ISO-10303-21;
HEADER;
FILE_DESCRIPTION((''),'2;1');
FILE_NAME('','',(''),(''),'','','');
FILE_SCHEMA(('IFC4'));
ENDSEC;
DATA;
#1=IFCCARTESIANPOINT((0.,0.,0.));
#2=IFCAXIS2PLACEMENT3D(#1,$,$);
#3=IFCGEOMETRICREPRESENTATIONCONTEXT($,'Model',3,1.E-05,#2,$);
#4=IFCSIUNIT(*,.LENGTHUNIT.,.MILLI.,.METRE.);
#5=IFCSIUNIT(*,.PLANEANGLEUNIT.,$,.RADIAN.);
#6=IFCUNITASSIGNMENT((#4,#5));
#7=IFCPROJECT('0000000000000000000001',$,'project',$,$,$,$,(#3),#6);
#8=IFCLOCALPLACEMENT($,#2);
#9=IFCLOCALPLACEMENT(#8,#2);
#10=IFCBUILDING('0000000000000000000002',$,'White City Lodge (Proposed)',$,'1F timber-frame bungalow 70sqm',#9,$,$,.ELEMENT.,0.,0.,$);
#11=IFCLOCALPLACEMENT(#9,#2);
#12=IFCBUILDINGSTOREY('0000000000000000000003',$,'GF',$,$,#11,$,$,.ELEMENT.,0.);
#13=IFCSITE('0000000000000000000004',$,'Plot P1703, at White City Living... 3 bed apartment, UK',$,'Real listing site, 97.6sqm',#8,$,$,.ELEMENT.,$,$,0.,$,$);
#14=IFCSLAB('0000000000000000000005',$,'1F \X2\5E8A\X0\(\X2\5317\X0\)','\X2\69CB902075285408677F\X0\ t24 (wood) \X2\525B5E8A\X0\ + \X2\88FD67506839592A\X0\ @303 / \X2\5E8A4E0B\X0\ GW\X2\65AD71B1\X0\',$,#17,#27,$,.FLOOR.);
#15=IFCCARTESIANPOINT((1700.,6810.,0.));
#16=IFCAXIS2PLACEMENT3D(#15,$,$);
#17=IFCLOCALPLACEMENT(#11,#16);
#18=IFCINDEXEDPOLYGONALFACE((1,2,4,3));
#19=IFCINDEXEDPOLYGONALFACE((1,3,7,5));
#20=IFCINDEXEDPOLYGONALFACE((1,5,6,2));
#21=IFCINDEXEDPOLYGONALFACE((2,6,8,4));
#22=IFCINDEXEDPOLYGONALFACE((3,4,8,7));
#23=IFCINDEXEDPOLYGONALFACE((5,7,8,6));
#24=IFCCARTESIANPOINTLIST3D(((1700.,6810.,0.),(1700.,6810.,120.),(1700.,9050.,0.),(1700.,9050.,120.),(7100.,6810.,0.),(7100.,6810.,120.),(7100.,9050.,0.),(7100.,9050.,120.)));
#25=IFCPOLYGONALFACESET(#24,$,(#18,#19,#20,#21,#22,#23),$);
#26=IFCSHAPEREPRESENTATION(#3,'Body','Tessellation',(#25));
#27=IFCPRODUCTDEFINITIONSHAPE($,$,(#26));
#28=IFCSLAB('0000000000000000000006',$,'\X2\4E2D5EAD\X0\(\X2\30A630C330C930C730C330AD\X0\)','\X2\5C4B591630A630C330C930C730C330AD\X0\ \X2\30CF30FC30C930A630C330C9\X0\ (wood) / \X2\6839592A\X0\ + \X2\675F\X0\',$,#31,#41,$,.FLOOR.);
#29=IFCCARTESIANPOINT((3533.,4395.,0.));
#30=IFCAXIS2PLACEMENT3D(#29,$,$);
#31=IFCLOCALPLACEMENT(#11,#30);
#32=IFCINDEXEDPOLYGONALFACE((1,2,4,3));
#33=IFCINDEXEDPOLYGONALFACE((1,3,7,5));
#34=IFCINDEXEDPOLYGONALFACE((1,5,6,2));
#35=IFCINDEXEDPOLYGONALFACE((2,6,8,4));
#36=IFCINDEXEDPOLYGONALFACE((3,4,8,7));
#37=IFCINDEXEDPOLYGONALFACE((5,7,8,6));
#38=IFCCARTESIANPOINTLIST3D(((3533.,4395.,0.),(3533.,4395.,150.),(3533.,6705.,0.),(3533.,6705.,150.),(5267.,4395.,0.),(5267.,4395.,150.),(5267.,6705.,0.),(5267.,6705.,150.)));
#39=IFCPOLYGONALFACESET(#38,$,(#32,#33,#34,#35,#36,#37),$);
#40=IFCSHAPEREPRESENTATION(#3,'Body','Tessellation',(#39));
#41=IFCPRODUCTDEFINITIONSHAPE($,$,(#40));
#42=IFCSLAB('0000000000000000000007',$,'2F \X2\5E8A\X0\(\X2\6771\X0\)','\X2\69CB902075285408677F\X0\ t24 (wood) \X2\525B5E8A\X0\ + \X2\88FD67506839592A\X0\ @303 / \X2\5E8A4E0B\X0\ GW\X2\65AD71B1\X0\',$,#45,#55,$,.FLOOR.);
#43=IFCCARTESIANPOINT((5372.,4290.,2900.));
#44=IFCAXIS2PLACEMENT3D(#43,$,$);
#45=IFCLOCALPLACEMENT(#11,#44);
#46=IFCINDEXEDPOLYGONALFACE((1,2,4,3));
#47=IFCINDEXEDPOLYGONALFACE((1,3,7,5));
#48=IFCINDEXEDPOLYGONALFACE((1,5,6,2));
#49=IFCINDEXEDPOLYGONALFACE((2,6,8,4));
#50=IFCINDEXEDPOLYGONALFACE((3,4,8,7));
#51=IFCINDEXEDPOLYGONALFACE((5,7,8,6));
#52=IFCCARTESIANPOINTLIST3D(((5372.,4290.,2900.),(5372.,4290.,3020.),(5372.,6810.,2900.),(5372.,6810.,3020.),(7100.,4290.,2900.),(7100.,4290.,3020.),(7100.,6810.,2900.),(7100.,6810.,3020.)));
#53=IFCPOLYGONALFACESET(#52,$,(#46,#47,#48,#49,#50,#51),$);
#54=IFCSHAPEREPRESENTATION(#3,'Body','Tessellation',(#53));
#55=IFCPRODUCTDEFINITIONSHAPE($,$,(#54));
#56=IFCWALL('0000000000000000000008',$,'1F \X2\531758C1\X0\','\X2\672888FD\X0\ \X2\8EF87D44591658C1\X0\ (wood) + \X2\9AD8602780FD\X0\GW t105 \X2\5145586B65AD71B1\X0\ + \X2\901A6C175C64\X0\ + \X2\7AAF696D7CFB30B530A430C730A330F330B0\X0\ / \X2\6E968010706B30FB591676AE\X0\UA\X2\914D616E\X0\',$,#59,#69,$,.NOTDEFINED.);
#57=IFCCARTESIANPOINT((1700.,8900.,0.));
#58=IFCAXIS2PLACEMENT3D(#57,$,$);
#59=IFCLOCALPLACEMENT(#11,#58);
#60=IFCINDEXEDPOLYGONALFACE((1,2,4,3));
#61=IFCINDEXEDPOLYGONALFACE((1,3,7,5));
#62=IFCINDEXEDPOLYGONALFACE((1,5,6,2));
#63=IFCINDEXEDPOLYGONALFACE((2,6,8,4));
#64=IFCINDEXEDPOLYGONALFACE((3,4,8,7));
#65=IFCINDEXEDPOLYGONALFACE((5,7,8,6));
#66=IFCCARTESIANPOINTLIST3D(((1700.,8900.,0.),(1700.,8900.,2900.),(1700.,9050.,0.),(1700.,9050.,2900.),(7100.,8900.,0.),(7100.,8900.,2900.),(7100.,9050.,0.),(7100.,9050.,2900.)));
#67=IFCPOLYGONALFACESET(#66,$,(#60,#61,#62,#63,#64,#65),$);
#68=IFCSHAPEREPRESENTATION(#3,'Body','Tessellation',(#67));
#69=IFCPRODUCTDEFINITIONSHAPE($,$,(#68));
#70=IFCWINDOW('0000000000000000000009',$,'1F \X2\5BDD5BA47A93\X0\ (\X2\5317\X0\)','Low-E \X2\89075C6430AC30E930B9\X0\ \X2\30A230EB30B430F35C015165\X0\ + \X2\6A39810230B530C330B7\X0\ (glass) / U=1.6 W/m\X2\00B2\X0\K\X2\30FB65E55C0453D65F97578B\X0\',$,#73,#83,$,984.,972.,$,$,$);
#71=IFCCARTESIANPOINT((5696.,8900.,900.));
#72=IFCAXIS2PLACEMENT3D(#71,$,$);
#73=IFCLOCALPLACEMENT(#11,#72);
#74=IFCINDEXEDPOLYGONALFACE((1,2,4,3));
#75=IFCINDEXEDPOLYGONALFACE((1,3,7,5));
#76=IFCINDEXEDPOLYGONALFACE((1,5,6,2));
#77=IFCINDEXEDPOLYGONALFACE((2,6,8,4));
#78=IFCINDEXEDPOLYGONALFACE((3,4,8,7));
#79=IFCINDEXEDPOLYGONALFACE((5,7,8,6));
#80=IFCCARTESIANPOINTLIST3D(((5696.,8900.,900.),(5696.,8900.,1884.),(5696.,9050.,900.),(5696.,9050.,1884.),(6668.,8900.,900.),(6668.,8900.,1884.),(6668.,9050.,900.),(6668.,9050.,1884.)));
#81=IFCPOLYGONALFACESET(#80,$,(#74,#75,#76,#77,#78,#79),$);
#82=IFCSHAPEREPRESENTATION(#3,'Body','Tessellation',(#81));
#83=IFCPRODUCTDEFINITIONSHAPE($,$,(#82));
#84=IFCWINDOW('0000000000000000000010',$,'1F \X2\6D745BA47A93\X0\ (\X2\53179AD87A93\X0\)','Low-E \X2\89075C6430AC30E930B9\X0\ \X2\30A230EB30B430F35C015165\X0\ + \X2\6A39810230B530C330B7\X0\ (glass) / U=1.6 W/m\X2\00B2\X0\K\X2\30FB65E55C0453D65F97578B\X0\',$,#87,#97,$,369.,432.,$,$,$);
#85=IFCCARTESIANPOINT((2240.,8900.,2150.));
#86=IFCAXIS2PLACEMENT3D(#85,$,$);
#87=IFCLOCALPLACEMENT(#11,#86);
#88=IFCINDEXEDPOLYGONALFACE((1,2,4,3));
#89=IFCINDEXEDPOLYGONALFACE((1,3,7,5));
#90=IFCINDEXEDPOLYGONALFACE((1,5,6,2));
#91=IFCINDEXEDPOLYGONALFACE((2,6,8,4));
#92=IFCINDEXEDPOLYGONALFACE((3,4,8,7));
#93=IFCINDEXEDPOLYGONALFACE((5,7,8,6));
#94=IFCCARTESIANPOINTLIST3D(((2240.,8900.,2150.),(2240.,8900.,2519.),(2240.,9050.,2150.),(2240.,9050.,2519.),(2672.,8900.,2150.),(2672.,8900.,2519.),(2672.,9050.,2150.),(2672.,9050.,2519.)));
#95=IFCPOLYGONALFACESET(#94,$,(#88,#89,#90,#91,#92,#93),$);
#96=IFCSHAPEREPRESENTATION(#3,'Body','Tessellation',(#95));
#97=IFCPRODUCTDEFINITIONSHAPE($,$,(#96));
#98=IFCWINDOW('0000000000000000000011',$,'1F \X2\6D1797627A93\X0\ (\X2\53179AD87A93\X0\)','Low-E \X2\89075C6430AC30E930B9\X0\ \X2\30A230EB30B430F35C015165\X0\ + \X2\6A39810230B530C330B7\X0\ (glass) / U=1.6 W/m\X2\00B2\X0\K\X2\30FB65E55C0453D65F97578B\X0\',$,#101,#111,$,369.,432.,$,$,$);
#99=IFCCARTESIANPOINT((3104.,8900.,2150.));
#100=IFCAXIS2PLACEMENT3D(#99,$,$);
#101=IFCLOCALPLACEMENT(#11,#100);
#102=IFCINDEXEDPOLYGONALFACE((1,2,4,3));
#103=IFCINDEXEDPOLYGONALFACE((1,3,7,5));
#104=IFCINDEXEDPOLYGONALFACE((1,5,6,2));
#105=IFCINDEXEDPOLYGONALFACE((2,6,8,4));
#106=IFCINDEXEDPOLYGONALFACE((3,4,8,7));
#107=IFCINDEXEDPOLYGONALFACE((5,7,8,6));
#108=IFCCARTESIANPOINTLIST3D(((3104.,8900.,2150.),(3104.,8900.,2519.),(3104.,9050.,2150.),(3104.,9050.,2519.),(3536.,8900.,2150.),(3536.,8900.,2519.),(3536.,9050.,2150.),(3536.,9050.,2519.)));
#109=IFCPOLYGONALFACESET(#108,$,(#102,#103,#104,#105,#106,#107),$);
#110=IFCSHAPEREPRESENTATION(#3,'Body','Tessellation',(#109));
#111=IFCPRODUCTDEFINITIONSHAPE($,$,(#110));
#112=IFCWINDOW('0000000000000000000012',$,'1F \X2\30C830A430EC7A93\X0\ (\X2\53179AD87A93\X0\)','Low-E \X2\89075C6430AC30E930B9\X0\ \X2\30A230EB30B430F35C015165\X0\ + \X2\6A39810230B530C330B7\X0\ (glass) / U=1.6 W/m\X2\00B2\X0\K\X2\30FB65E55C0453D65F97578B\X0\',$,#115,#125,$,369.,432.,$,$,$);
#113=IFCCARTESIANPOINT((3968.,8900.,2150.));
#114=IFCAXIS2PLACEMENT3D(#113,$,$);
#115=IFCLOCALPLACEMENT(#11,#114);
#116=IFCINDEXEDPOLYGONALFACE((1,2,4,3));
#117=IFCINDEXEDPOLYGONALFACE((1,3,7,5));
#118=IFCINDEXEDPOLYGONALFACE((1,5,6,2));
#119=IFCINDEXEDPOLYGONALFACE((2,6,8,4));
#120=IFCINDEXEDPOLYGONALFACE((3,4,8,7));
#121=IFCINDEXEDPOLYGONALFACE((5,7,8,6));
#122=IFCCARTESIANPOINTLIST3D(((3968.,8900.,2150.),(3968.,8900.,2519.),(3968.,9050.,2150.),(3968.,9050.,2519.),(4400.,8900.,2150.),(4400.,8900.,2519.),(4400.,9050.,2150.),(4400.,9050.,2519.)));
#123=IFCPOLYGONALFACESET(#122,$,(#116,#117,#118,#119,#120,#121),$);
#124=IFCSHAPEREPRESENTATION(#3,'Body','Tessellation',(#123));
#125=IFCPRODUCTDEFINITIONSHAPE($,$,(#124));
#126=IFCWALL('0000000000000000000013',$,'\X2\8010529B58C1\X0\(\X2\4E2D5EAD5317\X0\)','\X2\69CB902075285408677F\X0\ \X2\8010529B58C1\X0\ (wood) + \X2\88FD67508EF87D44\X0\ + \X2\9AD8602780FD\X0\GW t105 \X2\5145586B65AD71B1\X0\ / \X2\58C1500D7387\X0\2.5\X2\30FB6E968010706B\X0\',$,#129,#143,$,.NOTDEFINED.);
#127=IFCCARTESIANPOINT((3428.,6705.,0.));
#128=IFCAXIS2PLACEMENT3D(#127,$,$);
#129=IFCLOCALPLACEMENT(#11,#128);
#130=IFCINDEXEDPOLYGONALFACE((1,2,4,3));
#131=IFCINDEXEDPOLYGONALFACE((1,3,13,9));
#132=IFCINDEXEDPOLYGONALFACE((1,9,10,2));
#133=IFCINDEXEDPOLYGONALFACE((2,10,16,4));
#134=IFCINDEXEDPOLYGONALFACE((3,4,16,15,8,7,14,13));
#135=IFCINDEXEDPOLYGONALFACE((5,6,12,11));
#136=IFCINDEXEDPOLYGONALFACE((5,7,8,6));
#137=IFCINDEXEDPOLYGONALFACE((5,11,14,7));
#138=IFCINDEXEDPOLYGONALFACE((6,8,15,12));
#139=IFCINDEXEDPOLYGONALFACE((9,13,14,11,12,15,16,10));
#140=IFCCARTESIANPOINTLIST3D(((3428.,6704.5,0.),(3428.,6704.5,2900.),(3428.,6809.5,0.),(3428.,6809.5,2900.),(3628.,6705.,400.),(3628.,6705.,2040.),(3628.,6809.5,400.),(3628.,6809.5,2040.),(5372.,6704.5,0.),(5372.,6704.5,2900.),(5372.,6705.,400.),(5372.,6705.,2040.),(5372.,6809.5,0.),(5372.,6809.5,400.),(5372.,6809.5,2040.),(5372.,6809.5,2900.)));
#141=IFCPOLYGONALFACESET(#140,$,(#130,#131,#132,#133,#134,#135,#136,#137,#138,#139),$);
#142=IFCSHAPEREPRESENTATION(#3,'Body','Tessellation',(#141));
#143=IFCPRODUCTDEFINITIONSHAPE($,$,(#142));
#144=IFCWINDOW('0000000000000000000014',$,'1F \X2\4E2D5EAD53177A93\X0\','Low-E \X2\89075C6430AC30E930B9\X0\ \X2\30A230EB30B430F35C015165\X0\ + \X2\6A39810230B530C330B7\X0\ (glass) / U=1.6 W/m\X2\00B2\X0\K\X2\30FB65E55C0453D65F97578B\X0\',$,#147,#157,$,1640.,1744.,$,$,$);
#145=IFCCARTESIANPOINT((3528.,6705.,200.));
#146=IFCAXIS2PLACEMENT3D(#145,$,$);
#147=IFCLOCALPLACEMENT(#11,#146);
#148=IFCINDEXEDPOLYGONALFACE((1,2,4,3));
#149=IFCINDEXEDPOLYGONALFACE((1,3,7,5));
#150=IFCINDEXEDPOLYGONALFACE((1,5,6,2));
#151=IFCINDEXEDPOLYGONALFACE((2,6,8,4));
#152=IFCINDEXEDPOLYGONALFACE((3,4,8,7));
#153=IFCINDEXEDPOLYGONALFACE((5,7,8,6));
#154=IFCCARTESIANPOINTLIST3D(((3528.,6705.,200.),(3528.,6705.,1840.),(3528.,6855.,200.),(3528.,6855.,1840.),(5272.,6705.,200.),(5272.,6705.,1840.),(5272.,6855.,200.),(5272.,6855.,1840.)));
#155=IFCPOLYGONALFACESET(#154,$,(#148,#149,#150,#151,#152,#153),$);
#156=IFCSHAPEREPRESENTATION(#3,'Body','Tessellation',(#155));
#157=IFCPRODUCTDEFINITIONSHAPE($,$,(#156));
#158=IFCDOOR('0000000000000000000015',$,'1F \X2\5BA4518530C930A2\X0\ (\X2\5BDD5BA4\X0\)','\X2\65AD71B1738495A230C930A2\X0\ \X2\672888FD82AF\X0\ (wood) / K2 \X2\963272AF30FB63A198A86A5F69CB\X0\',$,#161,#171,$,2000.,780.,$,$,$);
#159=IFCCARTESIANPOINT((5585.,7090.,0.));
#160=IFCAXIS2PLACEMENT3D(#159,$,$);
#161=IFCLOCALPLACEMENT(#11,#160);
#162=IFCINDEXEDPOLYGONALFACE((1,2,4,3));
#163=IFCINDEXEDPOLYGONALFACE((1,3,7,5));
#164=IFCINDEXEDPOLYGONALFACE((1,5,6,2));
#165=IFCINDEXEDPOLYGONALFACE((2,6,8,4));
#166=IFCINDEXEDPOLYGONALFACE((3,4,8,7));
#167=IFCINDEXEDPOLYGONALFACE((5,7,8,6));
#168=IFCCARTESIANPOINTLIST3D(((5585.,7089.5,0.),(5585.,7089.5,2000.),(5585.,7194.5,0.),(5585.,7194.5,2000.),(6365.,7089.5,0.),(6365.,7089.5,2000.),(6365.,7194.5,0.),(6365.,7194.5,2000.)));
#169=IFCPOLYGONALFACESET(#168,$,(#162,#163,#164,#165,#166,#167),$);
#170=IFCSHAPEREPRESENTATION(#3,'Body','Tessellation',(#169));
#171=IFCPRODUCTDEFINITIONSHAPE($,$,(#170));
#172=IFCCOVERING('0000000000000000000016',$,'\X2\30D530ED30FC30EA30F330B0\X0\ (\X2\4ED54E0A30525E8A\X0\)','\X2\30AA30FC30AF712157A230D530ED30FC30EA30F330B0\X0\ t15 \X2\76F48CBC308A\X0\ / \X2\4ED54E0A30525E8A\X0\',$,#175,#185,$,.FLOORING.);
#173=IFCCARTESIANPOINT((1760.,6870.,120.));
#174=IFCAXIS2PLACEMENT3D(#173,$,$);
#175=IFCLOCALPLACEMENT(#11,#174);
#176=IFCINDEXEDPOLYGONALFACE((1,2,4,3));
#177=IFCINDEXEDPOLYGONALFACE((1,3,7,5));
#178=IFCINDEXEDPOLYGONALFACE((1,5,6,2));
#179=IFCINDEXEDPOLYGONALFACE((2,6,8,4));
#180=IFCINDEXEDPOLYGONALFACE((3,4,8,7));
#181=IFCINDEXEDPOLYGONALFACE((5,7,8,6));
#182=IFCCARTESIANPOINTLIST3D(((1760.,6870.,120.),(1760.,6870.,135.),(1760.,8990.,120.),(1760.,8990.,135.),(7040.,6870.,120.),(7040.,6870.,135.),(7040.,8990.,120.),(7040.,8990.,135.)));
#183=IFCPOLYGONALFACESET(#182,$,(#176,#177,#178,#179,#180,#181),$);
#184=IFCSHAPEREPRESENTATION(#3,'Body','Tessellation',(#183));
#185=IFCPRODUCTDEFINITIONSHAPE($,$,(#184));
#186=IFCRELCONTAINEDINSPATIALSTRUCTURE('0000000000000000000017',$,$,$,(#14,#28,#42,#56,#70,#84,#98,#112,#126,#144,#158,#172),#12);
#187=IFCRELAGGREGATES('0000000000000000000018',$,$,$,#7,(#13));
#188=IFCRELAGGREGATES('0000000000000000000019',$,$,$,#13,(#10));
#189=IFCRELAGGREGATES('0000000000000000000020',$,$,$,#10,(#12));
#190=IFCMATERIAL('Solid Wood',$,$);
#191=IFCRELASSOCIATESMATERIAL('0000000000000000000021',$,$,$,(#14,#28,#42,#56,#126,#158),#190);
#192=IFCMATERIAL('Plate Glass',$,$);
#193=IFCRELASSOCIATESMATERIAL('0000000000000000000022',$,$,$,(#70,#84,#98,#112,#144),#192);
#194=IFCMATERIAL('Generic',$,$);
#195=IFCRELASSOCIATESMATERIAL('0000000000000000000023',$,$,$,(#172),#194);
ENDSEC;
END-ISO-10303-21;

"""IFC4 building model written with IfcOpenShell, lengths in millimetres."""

from ifc_helpers import new_model, si_unit, frame, frame_2d, origin, place, context, project, spatial, rectangle, extrude, material, element, fill, save


model = new_model("IFC4")

# Units and contexts
model_context = context("Model", 3, precision=1e-05, world=origin())
ifc_project = project(units=[si_unit("LENGTHUNIT", "METRE", prefix="MILLI"), si_unit("PLANEANGLEUNIT", "RADIAN")], contexts=[model_context])

# Site, building, storey
site_placement = place(None, origin())
site = spatial("IfcSite", under=ifc_project, at=site_placement, Name="Plot P1703, at White City Living... 3 bed apartment, UK", ObjectType="Real listing site, 97.6sqm", CompositionType="ELEMENT", RefElevation=0.0)
building_placement = place(site_placement, origin())
building = spatial("IfcBuilding", under=site, at=building_placement, Name="White City Lodge (Proposed)", ObjectType="1F timber-frame bungalow 70sqm", CompositionType="ELEMENT", ElevationOfRefHeight=0.0, ElevationOfTerrain=0.0)
storey_placement = place(building_placement, origin())
storey = spatial("IfcBuildingStorey", under=building, at=storey_placement, Name="GF", CompositionType="ELEMENT", Elevation=0.0)

# Slabs
ifc_material_1 = material(Name="Solid Wood")
slab_1_placement = place(storey_placement, frame((1700.0, 6810.0, 0.0)))
element("IfcSlab", 1, at=slab_1_placement, inside=storey, material=ifc_material_1, Name="1F 床(北)", Description="構造用合板 t24 (wood) 剛床 + 製材根太 @303 / 床下 GW断熱", PredefinedType="FLOOR", context=model_context, shape_type="SweptSolid", body=[
    extrude(rectangle(XDim=5400.0, YDim=2240.0, at=frame_2d((2700.0, 1120.0))), frame((1700.0, 6810.0, 0.0)), (0.0, 0.0, 1.0), 120.0),
])
slab_2_placement = place(storey_placement, frame((3533.0, 4395.0, 0.0)))
element("IfcSlab", 2, at=slab_2_placement, inside=storey, material=ifc_material_1, Name="中庭(ウッドデッキ)", Description="屋外ウッドデッキ ハードウッド (wood) / 根太 + 束", PredefinedType="FLOOR", context=model_context, shape_type="SweptSolid", body=[
    extrude(rectangle(XDim=1734.0, YDim=2310.0, at=frame_2d((867.0, 1155.0))), frame((3533.0, 4395.0, 0.0)), (0.0, 0.0, 1.0), 150.0),
])
slab_3_placement = place(storey_placement, frame((5372.0, 4290.0, 2900.0)))
element("IfcSlab", 3, at=slab_3_placement, inside=storey, material=ifc_material_1, Name="2F 床(東)", Description="構造用合板 t24 (wood) 剛床 + 製材根太 @303 / 床下 GW断熱", PredefinedType="FLOOR", context=model_context, shape_type="SweptSolid", body=[
    extrude(rectangle(XDim=1728.0, YDim=2520.0, at=frame_2d((864.0, 1260.0))), frame((5372.0, 4290.0, 2900.0)), (0.0, 0.0, 1.0), 120.0),
])

# Wall, openings, windows
wall_1_placement = place(storey_placement, frame((1700.0, 8900.0, 0.0)))
wall_1 = element("IfcWall", 4, at=wall_1_placement, inside=storey, material=ifc_material_1, Name="1F 北壁", Description="木製 軸組外壁 (wood) + 高性能GW t105 充填断熱 + 通気層 + 窯業系サイディング / 準耐火・外皮UA配慮", PredefinedType="NOTDEFINED", context=model_context, shape_type="SweptSolid", body=[
    extrude(rectangle(XDim=5400.0, YDim=150.0, at=frame_2d((2700.0, 75.0))), frame((1700.0, 8900.0, 0.0)), (0.0, 0.0, 1.0), 2900.0),
])
opening_1_placement = place(storey_placement, frame((5696.0, 8900.0, 900.0)))
opening_1 = element("IfcOpeningElement", 5, at=opening_1_placement, cuts=wall_1, PredefinedType="NOTDEFINED", context=model_context, shape_type="SweptSolid", body=[
    extrude(rectangle(XDim=972.0, YDim=150.0, at=frame_2d((486.0, 75.0))), frame((5696.0, 8900.0, 900.0)), (0.0, 0.0, 1.0), 984.0),
])
opening_2_placement = place(storey_placement, frame((2240.0, 8900.0, 2150.0)))
opening_2 = element("IfcOpeningElement", 6, at=opening_2_placement, cuts=wall_1, PredefinedType="NOTDEFINED", context=model_context, shape_type="SweptSolid", body=[
    extrude(rectangle(XDim=432.0, YDim=150.0, at=frame_2d((216.0, 75.0))), frame((2240.0, 8900.0, 2150.0)), (0.0, 0.0, 1.0), 369.0),
])
opening_3_placement = place(storey_placement, frame((3104.0, 8900.0, 2150.0)))
opening_3 = element("IfcOpeningElement", 7, at=opening_3_placement, cuts=wall_1, PredefinedType="NOTDEFINED", context=model_context, shape_type="SweptSolid", body=[
    extrude(rectangle(XDim=432.0, YDim=150.0, at=frame_2d((216.0, 75.0))), frame((3104.0, 8900.0, 2150.0)), (0.0, 0.0, 1.0), 369.0),
])
opening_4_placement = place(storey_placement, frame((3968.0, 8900.0, 2150.0)))
opening_4 = element("IfcOpeningElement", 8, at=opening_4_placement, cuts=wall_1, PredefinedType="NOTDEFINED", context=model_context, shape_type="SweptSolid", body=[
    extrude(rectangle(XDim=432.0, YDim=150.0, at=frame_2d((216.0, 75.0))), frame((3968.0, 8900.0, 2150.0)), (0.0, 0.0, 1.0), 369.0),
])
ifc_material_2 = material(Name="Plate Glass")
window_1_placement = place(storey_placement, frame((5696.0, 8900.0, 900.0)))
window_1 = element("IfcWindow", 9, at=window_1_placement, inside=storey, material=ifc_material_2, Name="1F 寝室窓 (北)", Description="Low-E 複層ガラス アルゴン封入 + 樹脂サッシ (glass) / U=1.6 W/m²K・日射取得型", OverallHeight=984.0, OverallWidth=972.0, context=model_context, shape_type="SweptSolid", body=[
    extrude(rectangle(XDim=972.0, YDim=150.0, at=frame_2d((486.0, 75.0))), frame((5696.0, 8900.0, 900.0)), (0.0, 0.0, 1.0), 984.0),
])
fill(opening_1, window_1)
window_2_placement = place(storey_placement, frame((2240.0, 8900.0, 2150.0)))
window_2 = element("IfcWindow", 10, at=window_2_placement, inside=storey, material=ifc_material_2, Name="1F 浴室窓 (北高窓)", Description="Low-E 複層ガラス アルゴン封入 + 樹脂サッシ (glass) / U=1.6 W/m²K・日射取得型", OverallHeight=369.0, OverallWidth=432.0, context=model_context, shape_type="SweptSolid", body=[
    extrude(rectangle(XDim=432.0, YDim=150.0, at=frame_2d((216.0, 75.0))), frame((2240.0, 8900.0, 2150.0)), (0.0, 0.0, 1.0), 369.0),
])
fill(opening_2, window_2)
window_3_placement = place(storey_placement, frame((3104.0, 8900.0, 2150.0)))
window_3 = element("IfcWindow", 11, at=window_3_placement, inside=storey, material=ifc_material_2, Name="1F 洗面窓 (北高窓)", Description="Low-E 複層ガラス アルゴン封入 + 樹脂サッシ (glass) / U=1.6 W/m²K・日射取得型", OverallHeight=369.0, OverallWidth=432.0, context=model_context, shape_type="SweptSolid", body=[
    extrude(rectangle(XDim=432.0, YDim=150.0, at=frame_2d((216.0, 75.0))), frame((3104.0, 8900.0, 2150.0)), (0.0, 0.0, 1.0), 369.0),
])
fill(opening_3, window_3)
window_4_placement = place(storey_placement, frame((3968.0, 8900.0, 2150.0)))
window_4 = element("IfcWindow", 12, at=window_4_placement, inside=storey, material=ifc_material_2, Name="1F トイレ窓 (北高窓)", Description="Low-E 複層ガラス アルゴン封入 + 樹脂サッシ (glass) / U=1.6 W/m²K・日射取得型", OverallHeight=369.0, OverallWidth=432.0, context=model_context, shape_type="SweptSolid", body=[
    extrude(rectangle(XDim=432.0, YDim=150.0, at=frame_2d((216.0, 75.0))), frame((3968.0, 8900.0, 2150.0)), (0.0, 0.0, 1.0), 369.0),
])
fill(opening_4, window_4)

# Wall, opening, window
wall_2_placement = place(storey_placement, frame((3428.0, 6705.0, 0.0)))
wall_2 = element("IfcWall", 13, at=wall_2_placement, inside=storey, material=ifc_material_1, Name="耐力壁(中庭北)", Description="構造用合板 耐力壁 (wood) + 製材軸組 + 高性能GW t105 充填断熱 / 壁倍率2.5・準耐火", PredefinedType="NOTDEFINED", context=model_context, shape_type="SweptSolid", body=[
    extrude(rectangle(XDim=1944.0, YDim=105.0, at=frame_2d((972.0, 52.0))), frame((3428.0, 6705.0, 0.0)), (0.0, 0.0, 1.0), 2900.0),
])
opening_5_placement = place(storey_placement, frame((3528.0, 6705.0, 200.0)))
opening_5 = element("IfcOpeningElement", 14, at=opening_5_placement, cuts=wall_2, PredefinedType="NOTDEFINED", context=model_context, shape_type="SweptSolid", body=[
    extrude(rectangle(XDim=1744.0, YDim=150.0, at=frame_2d((872.0, 75.0))), frame((3528.0, 6705.0, 200.0)), (0.0, 0.0, 1.0), 1640.0),
])
window_5_placement = place(storey_placement, frame((3528.0, 6705.0, 200.0)))
window_5 = element("IfcWindow", 15, at=window_5_placement, inside=storey, material=ifc_material_2, Name="1F 中庭北窓", Description="Low-E 複層ガラス アルゴン封入 + 樹脂サッシ (glass) / U=1.6 W/m²K・日射取得型", OverallHeight=1640.0, OverallWidth=1744.0, context=model_context, shape_type="SweptSolid", body=[
    extrude(rectangle(XDim=1744.0, YDim=150.0, at=frame_2d((872.0, 75.0))), frame((3528.0, 6705.0, 200.0)), (0.0, 0.0, 1.0), 1640.0),
])
fill(opening_5, window_5)

# Door
door_1_placement = place(storey_placement, frame((5585.0, 7090.0, 0.0)))
element("IfcDoor", 16, at=door_1_placement, inside=storey, material=ifc_material_1, Name="1F 室内ドア (寝室)", Description="断熱玄関ドア 木製芯 (wood) / K2 防犯・採風機構", OverallHeight=2000.0, OverallWidth=780.0, context=model_context, shape_type="SweptSolid", body=[
    extrude(rectangle(XDim=780.0, YDim=105.0, at=frame_2d((390.0, 52.0))), frame((5585.0, 7090.0, 0.0)), (0.0, 0.0, 1.0), 2000.0),
])

# Covering
ifc_material_3 = material(Name="Generic")
covering_1_placement = place(storey_placement, frame((1760.0, 6870.0, 120.0)))
element("IfcCovering", 17, at=covering_1_placement, inside=storey, material=ifc_material_3, Name="フローリング (仕上げ床)", Description="オーク無垢フローリング t15 直貼り / 仕上げ床", PredefinedType="FLOORING", context=model_context, shape_type="SweptSolid", body=[
    extrude(rectangle(XDim=5280.0, YDim=2120.0, at=frame_2d((2640.0, 1060.0))), frame((1760.0, 6870.0, 120.0)), (0.0, 0.0, 1.0), 15.0),
])

save(model, "model.ifc")
